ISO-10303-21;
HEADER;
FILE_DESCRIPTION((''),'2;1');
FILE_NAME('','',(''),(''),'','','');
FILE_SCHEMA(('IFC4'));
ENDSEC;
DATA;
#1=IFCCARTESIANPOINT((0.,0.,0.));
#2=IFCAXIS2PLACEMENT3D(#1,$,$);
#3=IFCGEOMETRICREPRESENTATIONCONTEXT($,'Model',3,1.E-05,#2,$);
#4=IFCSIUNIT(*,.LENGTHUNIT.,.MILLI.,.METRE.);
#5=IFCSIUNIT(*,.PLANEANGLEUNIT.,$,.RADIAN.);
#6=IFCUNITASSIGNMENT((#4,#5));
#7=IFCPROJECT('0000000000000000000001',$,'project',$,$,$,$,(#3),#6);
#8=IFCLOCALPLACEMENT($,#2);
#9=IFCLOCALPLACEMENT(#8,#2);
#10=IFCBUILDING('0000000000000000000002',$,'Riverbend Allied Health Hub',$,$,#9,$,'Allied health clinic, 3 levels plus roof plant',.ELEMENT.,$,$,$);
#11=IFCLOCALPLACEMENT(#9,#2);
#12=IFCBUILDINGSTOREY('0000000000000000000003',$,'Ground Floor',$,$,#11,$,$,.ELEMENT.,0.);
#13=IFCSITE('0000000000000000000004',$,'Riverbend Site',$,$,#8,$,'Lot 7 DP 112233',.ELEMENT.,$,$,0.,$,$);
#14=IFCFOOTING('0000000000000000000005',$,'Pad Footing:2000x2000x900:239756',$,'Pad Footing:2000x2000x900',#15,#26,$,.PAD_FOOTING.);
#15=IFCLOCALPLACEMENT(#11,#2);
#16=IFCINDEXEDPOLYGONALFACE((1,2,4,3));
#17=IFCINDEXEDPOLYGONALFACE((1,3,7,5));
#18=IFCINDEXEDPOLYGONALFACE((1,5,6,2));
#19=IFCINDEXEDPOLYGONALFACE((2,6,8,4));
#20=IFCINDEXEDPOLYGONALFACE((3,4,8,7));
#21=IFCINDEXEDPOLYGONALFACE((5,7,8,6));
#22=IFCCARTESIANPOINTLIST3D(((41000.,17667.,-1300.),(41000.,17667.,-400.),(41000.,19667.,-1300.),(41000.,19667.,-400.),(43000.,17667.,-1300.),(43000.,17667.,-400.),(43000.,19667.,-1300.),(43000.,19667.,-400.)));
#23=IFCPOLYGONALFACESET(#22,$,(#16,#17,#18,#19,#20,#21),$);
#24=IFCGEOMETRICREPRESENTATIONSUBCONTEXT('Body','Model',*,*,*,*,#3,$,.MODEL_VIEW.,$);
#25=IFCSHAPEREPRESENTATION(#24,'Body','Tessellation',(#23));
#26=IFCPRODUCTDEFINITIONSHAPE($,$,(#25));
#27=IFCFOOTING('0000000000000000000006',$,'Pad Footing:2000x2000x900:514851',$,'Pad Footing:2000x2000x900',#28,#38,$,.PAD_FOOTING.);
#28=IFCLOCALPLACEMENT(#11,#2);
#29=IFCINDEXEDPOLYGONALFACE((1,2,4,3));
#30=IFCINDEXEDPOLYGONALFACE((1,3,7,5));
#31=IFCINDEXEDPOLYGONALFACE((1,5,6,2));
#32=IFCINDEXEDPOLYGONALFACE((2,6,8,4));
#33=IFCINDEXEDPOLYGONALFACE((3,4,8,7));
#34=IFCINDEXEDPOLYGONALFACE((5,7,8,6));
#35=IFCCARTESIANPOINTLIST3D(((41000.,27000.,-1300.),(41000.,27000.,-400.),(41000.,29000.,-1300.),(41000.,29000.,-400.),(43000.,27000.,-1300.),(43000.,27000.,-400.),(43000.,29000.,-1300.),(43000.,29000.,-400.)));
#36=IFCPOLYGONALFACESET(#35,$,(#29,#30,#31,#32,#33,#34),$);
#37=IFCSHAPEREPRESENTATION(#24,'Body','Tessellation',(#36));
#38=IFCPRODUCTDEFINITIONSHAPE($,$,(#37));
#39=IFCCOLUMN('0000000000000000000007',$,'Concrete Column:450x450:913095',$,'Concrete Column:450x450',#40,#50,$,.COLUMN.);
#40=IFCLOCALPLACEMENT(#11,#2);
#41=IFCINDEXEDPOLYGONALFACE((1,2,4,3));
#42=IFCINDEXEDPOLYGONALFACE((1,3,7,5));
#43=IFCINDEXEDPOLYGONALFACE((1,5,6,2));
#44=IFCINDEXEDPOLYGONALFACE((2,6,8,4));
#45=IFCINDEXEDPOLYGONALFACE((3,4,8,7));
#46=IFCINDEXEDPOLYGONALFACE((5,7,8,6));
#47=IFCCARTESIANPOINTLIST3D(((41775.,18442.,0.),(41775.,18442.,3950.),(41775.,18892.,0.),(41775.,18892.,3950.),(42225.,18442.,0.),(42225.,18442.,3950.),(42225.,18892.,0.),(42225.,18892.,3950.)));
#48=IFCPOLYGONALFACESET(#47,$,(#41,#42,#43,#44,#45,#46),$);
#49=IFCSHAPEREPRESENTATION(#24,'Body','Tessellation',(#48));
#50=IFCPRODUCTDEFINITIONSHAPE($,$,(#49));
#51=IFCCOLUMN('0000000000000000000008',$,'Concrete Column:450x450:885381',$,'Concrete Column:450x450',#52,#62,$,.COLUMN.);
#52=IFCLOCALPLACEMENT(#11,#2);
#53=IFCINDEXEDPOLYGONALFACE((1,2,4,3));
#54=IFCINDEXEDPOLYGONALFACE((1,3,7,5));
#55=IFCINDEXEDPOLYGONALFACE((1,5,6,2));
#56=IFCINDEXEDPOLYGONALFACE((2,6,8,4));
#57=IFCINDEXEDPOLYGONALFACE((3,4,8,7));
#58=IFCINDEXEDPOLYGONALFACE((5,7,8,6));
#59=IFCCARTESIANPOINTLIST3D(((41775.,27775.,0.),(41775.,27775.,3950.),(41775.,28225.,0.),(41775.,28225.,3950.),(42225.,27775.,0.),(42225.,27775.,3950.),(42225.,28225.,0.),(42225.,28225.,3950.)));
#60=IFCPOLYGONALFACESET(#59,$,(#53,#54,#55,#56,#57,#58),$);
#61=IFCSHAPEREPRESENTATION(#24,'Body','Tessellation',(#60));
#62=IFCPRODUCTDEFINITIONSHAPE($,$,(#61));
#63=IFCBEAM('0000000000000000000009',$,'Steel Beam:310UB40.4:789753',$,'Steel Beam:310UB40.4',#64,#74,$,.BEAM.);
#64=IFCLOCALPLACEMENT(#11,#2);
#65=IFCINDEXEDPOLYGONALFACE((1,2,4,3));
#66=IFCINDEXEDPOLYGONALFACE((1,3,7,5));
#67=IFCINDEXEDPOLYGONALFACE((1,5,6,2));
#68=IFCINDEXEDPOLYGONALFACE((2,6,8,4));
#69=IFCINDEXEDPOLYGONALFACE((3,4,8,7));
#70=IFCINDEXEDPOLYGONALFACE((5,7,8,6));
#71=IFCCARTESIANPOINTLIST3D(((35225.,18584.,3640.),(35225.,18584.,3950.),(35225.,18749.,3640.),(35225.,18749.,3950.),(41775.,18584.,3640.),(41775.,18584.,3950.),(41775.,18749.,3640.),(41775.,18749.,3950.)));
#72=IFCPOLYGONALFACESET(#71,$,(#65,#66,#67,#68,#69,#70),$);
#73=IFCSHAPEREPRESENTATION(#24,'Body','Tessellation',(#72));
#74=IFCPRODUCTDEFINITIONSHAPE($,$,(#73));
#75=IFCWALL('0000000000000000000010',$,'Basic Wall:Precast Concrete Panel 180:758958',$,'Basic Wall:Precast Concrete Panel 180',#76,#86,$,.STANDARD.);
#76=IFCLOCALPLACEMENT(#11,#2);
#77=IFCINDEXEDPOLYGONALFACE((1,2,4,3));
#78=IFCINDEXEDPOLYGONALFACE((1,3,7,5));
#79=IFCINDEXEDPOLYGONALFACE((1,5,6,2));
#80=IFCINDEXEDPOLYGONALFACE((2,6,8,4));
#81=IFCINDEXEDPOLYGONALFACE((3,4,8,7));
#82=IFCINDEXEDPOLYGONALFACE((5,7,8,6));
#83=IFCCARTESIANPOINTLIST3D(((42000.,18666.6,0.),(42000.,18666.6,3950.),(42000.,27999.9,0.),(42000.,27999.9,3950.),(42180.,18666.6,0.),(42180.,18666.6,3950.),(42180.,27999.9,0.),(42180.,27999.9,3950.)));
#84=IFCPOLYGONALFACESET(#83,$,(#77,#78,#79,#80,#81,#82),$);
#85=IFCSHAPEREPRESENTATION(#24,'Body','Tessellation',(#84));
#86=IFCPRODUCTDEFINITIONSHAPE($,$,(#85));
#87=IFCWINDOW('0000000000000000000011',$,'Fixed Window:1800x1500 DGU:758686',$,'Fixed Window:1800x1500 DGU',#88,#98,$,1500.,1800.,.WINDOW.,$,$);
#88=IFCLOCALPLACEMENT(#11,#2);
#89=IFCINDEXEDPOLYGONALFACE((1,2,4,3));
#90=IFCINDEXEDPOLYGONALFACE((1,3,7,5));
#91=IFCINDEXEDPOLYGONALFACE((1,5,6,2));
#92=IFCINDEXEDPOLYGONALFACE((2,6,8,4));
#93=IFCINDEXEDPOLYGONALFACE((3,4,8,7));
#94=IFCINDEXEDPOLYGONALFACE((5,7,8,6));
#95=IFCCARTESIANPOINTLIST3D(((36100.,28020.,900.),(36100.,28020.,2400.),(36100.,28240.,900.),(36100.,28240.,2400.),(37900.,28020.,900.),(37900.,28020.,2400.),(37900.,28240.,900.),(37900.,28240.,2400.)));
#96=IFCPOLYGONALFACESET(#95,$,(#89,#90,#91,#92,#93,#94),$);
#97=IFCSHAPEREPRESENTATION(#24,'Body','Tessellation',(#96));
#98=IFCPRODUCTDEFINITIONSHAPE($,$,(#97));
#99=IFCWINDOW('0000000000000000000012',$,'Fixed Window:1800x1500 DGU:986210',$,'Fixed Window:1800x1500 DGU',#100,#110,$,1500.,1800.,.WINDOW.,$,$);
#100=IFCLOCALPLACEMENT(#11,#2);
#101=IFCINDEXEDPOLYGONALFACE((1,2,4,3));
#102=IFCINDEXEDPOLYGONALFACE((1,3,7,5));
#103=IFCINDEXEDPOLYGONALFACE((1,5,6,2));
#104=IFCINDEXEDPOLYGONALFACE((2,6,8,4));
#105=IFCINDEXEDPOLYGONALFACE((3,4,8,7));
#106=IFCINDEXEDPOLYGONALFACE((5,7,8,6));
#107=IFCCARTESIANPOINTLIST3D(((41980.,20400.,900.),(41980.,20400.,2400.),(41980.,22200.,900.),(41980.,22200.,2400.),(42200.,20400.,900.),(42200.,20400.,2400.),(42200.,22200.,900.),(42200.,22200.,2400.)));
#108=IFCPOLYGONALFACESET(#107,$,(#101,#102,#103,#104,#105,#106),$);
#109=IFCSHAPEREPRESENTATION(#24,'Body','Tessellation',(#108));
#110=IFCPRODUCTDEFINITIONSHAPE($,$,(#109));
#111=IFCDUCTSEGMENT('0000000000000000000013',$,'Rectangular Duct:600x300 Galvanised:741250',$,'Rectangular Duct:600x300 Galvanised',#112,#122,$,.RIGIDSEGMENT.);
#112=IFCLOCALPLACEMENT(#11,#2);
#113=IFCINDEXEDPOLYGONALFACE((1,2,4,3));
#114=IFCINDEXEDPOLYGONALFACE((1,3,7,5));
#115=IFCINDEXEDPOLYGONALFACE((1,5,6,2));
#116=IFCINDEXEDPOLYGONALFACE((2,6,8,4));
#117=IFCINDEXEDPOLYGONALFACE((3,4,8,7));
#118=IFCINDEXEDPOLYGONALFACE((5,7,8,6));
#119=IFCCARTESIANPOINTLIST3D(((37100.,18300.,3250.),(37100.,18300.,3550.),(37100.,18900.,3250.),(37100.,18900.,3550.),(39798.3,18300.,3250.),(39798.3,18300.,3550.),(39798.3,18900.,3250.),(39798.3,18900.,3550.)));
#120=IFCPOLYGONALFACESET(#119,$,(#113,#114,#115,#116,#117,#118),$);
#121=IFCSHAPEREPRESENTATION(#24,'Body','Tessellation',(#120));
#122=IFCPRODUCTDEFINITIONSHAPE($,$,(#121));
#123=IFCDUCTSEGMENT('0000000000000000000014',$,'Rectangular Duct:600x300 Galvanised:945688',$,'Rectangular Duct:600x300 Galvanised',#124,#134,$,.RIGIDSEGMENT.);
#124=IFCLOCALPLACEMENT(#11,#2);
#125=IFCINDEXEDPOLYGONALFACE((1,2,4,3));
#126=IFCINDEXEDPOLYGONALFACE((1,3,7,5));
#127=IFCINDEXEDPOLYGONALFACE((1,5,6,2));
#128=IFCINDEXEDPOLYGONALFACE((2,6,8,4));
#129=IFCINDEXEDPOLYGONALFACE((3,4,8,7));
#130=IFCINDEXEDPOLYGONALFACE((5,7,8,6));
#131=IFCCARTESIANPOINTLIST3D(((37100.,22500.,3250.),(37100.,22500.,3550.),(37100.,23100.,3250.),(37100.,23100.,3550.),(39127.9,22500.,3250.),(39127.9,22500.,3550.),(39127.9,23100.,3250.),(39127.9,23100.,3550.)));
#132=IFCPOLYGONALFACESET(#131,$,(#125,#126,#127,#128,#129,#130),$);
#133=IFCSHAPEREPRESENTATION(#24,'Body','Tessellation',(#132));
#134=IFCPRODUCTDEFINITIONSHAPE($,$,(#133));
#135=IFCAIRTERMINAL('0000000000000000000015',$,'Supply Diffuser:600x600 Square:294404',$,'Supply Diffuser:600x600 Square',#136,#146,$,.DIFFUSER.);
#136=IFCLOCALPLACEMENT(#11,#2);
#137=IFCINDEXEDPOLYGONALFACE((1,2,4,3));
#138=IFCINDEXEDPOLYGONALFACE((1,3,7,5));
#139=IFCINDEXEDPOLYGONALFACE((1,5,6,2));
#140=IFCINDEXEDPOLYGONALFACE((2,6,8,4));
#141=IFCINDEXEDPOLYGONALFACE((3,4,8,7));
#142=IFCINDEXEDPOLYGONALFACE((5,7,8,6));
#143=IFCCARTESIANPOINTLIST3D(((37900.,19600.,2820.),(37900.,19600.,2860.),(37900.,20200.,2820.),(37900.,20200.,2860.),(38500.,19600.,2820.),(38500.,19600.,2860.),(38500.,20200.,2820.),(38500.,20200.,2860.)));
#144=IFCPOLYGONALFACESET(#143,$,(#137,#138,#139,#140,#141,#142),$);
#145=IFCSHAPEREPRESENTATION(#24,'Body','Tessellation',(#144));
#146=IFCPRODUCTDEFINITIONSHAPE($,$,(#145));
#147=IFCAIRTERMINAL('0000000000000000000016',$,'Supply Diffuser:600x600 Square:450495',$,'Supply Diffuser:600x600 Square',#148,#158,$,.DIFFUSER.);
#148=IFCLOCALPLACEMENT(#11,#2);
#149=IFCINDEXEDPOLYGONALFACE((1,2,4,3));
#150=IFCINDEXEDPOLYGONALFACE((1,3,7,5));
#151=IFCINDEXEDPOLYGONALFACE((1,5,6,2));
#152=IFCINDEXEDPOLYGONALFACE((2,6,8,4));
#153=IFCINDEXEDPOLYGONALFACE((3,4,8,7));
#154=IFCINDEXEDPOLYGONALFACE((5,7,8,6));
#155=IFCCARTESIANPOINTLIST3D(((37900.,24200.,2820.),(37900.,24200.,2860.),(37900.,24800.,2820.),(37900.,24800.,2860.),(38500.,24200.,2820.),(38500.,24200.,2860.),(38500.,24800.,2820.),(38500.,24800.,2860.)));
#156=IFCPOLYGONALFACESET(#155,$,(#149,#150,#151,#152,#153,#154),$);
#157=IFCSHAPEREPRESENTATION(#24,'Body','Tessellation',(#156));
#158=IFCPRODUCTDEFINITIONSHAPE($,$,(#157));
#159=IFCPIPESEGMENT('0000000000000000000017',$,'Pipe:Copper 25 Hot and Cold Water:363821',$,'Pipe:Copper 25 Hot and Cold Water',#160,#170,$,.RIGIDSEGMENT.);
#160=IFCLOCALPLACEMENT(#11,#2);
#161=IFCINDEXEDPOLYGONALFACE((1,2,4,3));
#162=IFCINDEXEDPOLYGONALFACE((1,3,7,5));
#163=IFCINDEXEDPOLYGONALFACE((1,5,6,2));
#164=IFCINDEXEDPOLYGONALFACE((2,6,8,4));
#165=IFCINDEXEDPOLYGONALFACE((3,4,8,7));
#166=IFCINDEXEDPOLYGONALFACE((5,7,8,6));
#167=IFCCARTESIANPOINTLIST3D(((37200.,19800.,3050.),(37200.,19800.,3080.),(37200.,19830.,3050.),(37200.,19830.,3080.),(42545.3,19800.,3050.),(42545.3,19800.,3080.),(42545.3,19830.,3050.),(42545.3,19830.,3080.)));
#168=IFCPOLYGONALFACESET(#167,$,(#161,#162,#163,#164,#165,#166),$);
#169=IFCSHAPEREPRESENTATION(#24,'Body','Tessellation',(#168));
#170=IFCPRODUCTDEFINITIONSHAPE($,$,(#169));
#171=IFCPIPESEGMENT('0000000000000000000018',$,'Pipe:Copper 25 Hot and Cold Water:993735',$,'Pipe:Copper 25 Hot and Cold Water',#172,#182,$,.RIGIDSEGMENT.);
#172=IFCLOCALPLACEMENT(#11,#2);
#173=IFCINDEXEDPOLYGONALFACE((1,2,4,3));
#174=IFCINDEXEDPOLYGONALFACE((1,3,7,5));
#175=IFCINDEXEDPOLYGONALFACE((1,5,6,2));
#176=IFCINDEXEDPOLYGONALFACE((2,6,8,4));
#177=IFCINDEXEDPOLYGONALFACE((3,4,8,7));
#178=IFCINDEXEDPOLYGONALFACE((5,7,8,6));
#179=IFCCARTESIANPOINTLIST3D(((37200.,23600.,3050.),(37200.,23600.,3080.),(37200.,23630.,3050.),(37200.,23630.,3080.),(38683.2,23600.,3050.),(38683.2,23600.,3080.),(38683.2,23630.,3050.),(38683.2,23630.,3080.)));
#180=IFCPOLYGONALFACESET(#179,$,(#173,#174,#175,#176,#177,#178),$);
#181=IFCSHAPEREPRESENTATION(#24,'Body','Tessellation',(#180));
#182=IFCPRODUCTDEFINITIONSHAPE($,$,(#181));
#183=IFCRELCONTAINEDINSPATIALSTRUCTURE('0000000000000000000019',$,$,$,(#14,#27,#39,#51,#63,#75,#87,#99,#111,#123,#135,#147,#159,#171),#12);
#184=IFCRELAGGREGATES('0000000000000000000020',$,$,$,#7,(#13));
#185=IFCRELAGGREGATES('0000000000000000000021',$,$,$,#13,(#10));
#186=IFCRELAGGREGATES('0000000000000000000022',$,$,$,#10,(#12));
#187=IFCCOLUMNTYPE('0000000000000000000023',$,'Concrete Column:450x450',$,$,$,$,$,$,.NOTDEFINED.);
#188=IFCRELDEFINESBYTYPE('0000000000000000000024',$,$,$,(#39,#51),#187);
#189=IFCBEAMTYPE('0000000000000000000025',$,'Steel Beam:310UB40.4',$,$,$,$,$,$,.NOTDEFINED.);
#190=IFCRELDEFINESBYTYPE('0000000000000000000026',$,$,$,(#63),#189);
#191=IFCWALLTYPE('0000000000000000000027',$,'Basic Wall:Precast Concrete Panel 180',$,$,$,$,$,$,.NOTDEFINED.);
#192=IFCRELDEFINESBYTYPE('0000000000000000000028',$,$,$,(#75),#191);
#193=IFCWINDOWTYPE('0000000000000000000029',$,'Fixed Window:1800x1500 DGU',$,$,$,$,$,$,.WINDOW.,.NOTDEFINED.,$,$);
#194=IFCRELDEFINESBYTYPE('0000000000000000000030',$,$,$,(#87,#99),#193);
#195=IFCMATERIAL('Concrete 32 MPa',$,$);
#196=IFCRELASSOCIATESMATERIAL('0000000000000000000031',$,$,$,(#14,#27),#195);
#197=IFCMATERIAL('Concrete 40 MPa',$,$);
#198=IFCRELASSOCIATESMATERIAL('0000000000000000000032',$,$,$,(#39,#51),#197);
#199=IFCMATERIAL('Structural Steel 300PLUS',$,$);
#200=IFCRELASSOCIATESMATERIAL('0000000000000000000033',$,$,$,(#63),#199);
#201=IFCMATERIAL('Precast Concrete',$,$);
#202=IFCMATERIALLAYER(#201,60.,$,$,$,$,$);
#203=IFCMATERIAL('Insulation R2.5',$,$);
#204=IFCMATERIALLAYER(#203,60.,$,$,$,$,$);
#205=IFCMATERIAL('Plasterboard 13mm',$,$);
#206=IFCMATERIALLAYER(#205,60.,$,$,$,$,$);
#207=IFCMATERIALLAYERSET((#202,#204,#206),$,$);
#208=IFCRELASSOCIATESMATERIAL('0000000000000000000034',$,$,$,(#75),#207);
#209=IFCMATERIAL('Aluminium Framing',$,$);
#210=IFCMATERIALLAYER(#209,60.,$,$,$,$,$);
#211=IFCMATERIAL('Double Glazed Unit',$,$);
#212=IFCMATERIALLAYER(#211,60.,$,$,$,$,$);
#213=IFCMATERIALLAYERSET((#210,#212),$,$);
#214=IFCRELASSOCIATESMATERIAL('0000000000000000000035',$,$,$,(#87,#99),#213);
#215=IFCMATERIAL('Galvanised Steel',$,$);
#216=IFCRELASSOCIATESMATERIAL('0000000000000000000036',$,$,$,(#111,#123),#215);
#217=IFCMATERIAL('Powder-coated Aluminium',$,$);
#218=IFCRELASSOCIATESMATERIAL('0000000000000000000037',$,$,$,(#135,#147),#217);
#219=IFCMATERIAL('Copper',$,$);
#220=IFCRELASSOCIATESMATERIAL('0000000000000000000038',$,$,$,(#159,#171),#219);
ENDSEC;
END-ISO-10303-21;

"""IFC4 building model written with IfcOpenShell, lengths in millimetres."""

from ifc_helpers import new_model, si_unit, frame, frame_2d, origin, place, context, subcontext, project, spatial, rectangle, extrude, material, layer, layer_set, layer_usage, type_object, element, save


model = new_model("IFC4")

# Units and contexts
model_context = context("Model", 3, precision=1e-05, world=origin())
body_context = subcontext(model_context, "Body", "Model", "MODEL_VIEW")
ifc_project = project(units=[si_unit("LENGTHUNIT", "METRE", prefix="MILLI"), si_unit("PLANEANGLEUNIT", "RADIAN")], contexts=[model_context])

# Site, building, storey
site_placement = place(None, origin())
site = spatial("IfcSite", under=ifc_project, at=site_placement, Name="Riverbend Site", LongName="Lot 7 DP 112233", CompositionType="ELEMENT", RefElevation=0.0)
building_placement = place(site_placement, origin())
building = spatial("IfcBuilding", under=site, at=building_placement, Name="Riverbend Allied Health Hub", LongName="Allied health clinic, 3 levels plus roof plant", CompositionType="ELEMENT")
storey_placement = place(building_placement, origin())
storey = spatial("IfcBuildingStorey", under=building, at=storey_placement, Name="Ground Floor", CompositionType="ELEMENT", Elevation=0.0)

# Footings
ifc_material_1 = material(Name="Concrete 32 MPa")
for number, where, name in (
    (1, (41000.0, 17667.0, -1300.0), "Pad Footing:2000x2000x900:239756"),
    (2, (41000.0, 27000.0, -1300.0), "Pad Footing:2000x2000x900:514851"),
):
    element("IfcFooting", number, at=place(storey_placement, frame(where)), inside=storey, material=ifc_material_1, Name=name, ObjectType="Pad Footing:2000x2000x900", PredefinedType="PAD_FOOTING", context=body_context, shape_type="SweptSolid", body=[
        extrude(rectangle(XDim=2000.0, YDim=2000.0, at=frame_2d((1000.0, 1000.0))), origin(), (0.0, 0.0, 1.0), 900.0),
    ])

# Columns
ifc_material_2 = material(Name="Concrete 40 MPa")
column_type = type_object("IfcColumnType", Name="Concrete Column:450x450", PredefinedType="NOTDEFINED")
for number, where, name in (
    (3, (41775.0, 18442.0, 0.0), "Concrete Column:450x450:913095"),
    (4, (41775.0, 27775.0, 0.0), "Concrete Column:450x450:885381"),
):
    element("IfcColumn", number, at=place(storey_placement, frame(where)), inside=storey, type_object=column_type, material=ifc_material_2, Name=name, ObjectType="Concrete Column:450x450", PredefinedType="COLUMN", context=body_context, shape_type="SweptSolid", body=[
        extrude(rectangle(XDim=450.0, YDim=450.0, at=frame_2d((225.0, 225.0))), origin(), (0.0, 0.0, 1.0), 3950.0),
    ])

# Beam
ifc_material_3 = material(Name="Structural Steel 300PLUS")
beam_type = type_object("IfcBeamType", Name="Steel Beam:310UB40.4", PredefinedType="NOTDEFINED")
beam_placement = place(storey_placement, frame((35225.0, 18584.0, 3640.0)))
element("IfcBeam", 5, at=beam_placement, inside=storey, type_object=beam_type, material=ifc_material_3, Name="Steel Beam:310UB40.4:789753", ObjectType="Steel Beam:310UB40.4", PredefinedType="BEAM", context=body_context, shape_type="SweptSolid", body=[
    extrude(rectangle(XDim=6550.0, YDim=165.0, at=frame_2d((3275.0, 82.5))), origin(), (0.0, 0.0, 1.0), 310.0),
])

# Wall
ifc_material_4 = material(Name="Precast Concrete")
ifc_layer_1 = layer(ifc_material_4, 60.0)
ifc_material_5 = material(Name="Insulation R2.5")
ifc_layer_2 = layer(ifc_material_5, 60.0)
ifc_material_6 = material(Name="Plasterboard 13mm")
ifc_layer_3 = layer(ifc_material_6, 60.0)
ifc_layer_set_1 = layer_set([ifc_layer_1, ifc_layer_2, ifc_layer_3])
ifc_layer_usage_1 = layer_usage(ifc_layer_set_1, "AXIS2", "POSITIVE", 0.0)
wall_type = type_object("IfcWallType", Name="Basic Wall:Precast Concrete Panel 180", PredefinedType="NOTDEFINED")
wall_placement = place(storey_placement, frame((42180.0, 18666.6, 0.0), z_axis=(0.0, 0.0, 1.0), x_axis=(0.0, 1.0, 0.0)))
element("IfcWall", 6, at=wall_placement, inside=storey, type_object=wall_type, material=ifc_layer_usage_1, Name="Basic Wall:Precast Concrete Panel 180:758958", ObjectType="Basic Wall:Precast Concrete Panel 180", PredefinedType="STANDARD", context=body_context, shape_type="SweptSolid", body=[
    extrude(rectangle(XDim=9333.3, YDim=180.0, at=frame_2d((4666.6, 90.0))), origin(), (0.0, 0.0, 1.0), 3950.0),
])

# Windows
ifc_material_7 = material(Name="Aluminium Framing")
ifc_layer_4 = layer(ifc_material_7, 60.0)
ifc_material_8 = material(Name="Double Glazed Unit")
ifc_layer_5 = layer(ifc_material_8, 60.0)
ifc_layer_set_2 = layer_set([ifc_layer_4, ifc_layer_5])
ifc_layer_usage_2 = layer_usage(ifc_layer_set_2, "AXIS2", "POSITIVE", 0.0)
window_type = type_object("IfcWindowType", Name="Fixed Window:1800x1500 DGU", PartitioningType="NOTDEFINED", PredefinedType="WINDOW")
window_1_placement = place(storey_placement, frame((36100.0, 28020.0, 900.0)))
element("IfcWindow", 7, at=window_1_placement, inside=storey, type_object=window_type, material=ifc_layer_usage_2, Name="Fixed Window:1800x1500 DGU:758686", ObjectType="Fixed Window:1800x1500 DGU", OverallHeight=1500.0, OverallWidth=1800.0, PredefinedType="WINDOW", context=body_context, shape_type="SweptSolid", body=[
    extrude(rectangle(XDim=1800.0, YDim=220.0, at=frame_2d((900.0, 110.0))), origin(), (0.0, 0.0, 1.0), 1500.0),
])
window_2_placement = place(storey_placement, frame((42200.0, 20400.0, 900.0), z_axis=(0.0, 0.0, 1.0), x_axis=(0.0, 1.0, 0.0)))
element("IfcWindow", 8, at=window_2_placement, inside=storey, type_object=window_type, material=ifc_layer_usage_2, Name="Fixed Window:1800x1500 DGU:986210", ObjectType="Fixed Window:1800x1500 DGU", OverallHeight=1500.0, OverallWidth=1800.0, PredefinedType="WINDOW", context=body_context, shape_type="SweptSolid", body=[
    extrude(rectangle(XDim=1800.0, YDim=220.0, at=frame_2d((900.0, 110.0))), origin(), (0.0, 0.0, 1.0), 1500.0),
])

# Duct segments
ifc_material_9 = material(Name="Galvanised Steel")
duct_segment_1_placement = place(storey_placement, frame((37100.0, 18300.0, 3250.0)))
element("IfcDuctSegment", 9, at=duct_segment_1_placement, inside=storey, material=ifc_material_9, Name="Rectangular Duct:600x300 Galvanised:741250", ObjectType="Rectangular Duct:600x300 Galvanised", PredefinedType="RIGIDSEGMENT", context=body_context, shape_type="SweptSolid", body=[
    extrude(rectangle(XDim=2698.3, YDim=600.0, at=frame_2d((1349.1, 300.0))), origin(), (0.0, 0.0, 1.0), 300.0),
])
duct_segment_2_placement = place(storey_placement, frame((37100.0, 22500.0, 3250.0)))
element("IfcDuctSegment", 10, at=duct_segment_2_placement, inside=storey, material=ifc_material_9, Name="Rectangular Duct:600x300 Galvanised:945688", ObjectType="Rectangular Duct:600x300 Galvanised", PredefinedType="RIGIDSEGMENT", context=body_context, shape_type="SweptSolid", body=[
    extrude(rectangle(XDim=2027.9, YDim=600.0, at=frame_2d((1013.9, 300.0))), origin(), (0.0, 0.0, 1.0), 300.0),
])

# Air terminals
ifc_material_10 = material(Name="Powder-coated Aluminium")
for number, where, name in (
    (11, (37900.0, 19600.0, 2820.0), "Supply Diffuser:600x600 Square:294404"),
    (12, (37900.0, 24200.0, 2820.0), "Supply Diffuser:600x600 Square:450495"),
):
    element("IfcAirTerminal", number, at=place(storey_placement, frame(where)), inside=storey, material=ifc_material_10, Name=name, ObjectType="Supply Diffuser:600x600 Square", PredefinedType="DIFFUSER", context=body_context, shape_type="SweptSolid", body=[
        extrude(rectangle(XDim=600.0, YDim=600.0, at=frame_2d((300.0, 300.0))), origin(), (0.0, 0.0, 1.0), 40.0),
    ])

# Pipe segments
ifc_material_11 = material(Name="Copper")
pipe_segment_1_placement = place(storey_placement, frame((37200.0, 19800.0, 3050.0)))
element("IfcPipeSegment", 13, at=pipe_segment_1_placement, inside=storey, material=ifc_material_11, Name="Pipe:Copper 25 Hot and Cold Water:363821", ObjectType="Pipe:Copper 25 Hot and Cold Water", PredefinedType="RIGIDSEGMENT", context=body_context, shape_type="SweptSolid", body=[
    extrude(rectangle(XDim=5345.3, YDim=30.0, at=frame_2d((2672.7, 15.0))), origin(), (0.0, 0.0, 1.0), 30.0),
])
pipe_segment_2_placement = place(storey_placement, frame((37200.0, 23600.0, 3050.0)))
element("IfcPipeSegment", 14, at=pipe_segment_2_placement, inside=storey, material=ifc_material_11, Name="Pipe:Copper 25 Hot and Cold Water:993735", ObjectType="Pipe:Copper 25 Hot and Cold Water", PredefinedType="RIGIDSEGMENT", context=body_context, shape_type="SweptSolid", body=[
    extrude(rectangle(XDim=1483.2, YDim=30.0, at=frame_2d((741.6, 15.0))), origin(), (0.0, 0.0, 1.0), 30.0),
])

save(model, "model.ifc")
